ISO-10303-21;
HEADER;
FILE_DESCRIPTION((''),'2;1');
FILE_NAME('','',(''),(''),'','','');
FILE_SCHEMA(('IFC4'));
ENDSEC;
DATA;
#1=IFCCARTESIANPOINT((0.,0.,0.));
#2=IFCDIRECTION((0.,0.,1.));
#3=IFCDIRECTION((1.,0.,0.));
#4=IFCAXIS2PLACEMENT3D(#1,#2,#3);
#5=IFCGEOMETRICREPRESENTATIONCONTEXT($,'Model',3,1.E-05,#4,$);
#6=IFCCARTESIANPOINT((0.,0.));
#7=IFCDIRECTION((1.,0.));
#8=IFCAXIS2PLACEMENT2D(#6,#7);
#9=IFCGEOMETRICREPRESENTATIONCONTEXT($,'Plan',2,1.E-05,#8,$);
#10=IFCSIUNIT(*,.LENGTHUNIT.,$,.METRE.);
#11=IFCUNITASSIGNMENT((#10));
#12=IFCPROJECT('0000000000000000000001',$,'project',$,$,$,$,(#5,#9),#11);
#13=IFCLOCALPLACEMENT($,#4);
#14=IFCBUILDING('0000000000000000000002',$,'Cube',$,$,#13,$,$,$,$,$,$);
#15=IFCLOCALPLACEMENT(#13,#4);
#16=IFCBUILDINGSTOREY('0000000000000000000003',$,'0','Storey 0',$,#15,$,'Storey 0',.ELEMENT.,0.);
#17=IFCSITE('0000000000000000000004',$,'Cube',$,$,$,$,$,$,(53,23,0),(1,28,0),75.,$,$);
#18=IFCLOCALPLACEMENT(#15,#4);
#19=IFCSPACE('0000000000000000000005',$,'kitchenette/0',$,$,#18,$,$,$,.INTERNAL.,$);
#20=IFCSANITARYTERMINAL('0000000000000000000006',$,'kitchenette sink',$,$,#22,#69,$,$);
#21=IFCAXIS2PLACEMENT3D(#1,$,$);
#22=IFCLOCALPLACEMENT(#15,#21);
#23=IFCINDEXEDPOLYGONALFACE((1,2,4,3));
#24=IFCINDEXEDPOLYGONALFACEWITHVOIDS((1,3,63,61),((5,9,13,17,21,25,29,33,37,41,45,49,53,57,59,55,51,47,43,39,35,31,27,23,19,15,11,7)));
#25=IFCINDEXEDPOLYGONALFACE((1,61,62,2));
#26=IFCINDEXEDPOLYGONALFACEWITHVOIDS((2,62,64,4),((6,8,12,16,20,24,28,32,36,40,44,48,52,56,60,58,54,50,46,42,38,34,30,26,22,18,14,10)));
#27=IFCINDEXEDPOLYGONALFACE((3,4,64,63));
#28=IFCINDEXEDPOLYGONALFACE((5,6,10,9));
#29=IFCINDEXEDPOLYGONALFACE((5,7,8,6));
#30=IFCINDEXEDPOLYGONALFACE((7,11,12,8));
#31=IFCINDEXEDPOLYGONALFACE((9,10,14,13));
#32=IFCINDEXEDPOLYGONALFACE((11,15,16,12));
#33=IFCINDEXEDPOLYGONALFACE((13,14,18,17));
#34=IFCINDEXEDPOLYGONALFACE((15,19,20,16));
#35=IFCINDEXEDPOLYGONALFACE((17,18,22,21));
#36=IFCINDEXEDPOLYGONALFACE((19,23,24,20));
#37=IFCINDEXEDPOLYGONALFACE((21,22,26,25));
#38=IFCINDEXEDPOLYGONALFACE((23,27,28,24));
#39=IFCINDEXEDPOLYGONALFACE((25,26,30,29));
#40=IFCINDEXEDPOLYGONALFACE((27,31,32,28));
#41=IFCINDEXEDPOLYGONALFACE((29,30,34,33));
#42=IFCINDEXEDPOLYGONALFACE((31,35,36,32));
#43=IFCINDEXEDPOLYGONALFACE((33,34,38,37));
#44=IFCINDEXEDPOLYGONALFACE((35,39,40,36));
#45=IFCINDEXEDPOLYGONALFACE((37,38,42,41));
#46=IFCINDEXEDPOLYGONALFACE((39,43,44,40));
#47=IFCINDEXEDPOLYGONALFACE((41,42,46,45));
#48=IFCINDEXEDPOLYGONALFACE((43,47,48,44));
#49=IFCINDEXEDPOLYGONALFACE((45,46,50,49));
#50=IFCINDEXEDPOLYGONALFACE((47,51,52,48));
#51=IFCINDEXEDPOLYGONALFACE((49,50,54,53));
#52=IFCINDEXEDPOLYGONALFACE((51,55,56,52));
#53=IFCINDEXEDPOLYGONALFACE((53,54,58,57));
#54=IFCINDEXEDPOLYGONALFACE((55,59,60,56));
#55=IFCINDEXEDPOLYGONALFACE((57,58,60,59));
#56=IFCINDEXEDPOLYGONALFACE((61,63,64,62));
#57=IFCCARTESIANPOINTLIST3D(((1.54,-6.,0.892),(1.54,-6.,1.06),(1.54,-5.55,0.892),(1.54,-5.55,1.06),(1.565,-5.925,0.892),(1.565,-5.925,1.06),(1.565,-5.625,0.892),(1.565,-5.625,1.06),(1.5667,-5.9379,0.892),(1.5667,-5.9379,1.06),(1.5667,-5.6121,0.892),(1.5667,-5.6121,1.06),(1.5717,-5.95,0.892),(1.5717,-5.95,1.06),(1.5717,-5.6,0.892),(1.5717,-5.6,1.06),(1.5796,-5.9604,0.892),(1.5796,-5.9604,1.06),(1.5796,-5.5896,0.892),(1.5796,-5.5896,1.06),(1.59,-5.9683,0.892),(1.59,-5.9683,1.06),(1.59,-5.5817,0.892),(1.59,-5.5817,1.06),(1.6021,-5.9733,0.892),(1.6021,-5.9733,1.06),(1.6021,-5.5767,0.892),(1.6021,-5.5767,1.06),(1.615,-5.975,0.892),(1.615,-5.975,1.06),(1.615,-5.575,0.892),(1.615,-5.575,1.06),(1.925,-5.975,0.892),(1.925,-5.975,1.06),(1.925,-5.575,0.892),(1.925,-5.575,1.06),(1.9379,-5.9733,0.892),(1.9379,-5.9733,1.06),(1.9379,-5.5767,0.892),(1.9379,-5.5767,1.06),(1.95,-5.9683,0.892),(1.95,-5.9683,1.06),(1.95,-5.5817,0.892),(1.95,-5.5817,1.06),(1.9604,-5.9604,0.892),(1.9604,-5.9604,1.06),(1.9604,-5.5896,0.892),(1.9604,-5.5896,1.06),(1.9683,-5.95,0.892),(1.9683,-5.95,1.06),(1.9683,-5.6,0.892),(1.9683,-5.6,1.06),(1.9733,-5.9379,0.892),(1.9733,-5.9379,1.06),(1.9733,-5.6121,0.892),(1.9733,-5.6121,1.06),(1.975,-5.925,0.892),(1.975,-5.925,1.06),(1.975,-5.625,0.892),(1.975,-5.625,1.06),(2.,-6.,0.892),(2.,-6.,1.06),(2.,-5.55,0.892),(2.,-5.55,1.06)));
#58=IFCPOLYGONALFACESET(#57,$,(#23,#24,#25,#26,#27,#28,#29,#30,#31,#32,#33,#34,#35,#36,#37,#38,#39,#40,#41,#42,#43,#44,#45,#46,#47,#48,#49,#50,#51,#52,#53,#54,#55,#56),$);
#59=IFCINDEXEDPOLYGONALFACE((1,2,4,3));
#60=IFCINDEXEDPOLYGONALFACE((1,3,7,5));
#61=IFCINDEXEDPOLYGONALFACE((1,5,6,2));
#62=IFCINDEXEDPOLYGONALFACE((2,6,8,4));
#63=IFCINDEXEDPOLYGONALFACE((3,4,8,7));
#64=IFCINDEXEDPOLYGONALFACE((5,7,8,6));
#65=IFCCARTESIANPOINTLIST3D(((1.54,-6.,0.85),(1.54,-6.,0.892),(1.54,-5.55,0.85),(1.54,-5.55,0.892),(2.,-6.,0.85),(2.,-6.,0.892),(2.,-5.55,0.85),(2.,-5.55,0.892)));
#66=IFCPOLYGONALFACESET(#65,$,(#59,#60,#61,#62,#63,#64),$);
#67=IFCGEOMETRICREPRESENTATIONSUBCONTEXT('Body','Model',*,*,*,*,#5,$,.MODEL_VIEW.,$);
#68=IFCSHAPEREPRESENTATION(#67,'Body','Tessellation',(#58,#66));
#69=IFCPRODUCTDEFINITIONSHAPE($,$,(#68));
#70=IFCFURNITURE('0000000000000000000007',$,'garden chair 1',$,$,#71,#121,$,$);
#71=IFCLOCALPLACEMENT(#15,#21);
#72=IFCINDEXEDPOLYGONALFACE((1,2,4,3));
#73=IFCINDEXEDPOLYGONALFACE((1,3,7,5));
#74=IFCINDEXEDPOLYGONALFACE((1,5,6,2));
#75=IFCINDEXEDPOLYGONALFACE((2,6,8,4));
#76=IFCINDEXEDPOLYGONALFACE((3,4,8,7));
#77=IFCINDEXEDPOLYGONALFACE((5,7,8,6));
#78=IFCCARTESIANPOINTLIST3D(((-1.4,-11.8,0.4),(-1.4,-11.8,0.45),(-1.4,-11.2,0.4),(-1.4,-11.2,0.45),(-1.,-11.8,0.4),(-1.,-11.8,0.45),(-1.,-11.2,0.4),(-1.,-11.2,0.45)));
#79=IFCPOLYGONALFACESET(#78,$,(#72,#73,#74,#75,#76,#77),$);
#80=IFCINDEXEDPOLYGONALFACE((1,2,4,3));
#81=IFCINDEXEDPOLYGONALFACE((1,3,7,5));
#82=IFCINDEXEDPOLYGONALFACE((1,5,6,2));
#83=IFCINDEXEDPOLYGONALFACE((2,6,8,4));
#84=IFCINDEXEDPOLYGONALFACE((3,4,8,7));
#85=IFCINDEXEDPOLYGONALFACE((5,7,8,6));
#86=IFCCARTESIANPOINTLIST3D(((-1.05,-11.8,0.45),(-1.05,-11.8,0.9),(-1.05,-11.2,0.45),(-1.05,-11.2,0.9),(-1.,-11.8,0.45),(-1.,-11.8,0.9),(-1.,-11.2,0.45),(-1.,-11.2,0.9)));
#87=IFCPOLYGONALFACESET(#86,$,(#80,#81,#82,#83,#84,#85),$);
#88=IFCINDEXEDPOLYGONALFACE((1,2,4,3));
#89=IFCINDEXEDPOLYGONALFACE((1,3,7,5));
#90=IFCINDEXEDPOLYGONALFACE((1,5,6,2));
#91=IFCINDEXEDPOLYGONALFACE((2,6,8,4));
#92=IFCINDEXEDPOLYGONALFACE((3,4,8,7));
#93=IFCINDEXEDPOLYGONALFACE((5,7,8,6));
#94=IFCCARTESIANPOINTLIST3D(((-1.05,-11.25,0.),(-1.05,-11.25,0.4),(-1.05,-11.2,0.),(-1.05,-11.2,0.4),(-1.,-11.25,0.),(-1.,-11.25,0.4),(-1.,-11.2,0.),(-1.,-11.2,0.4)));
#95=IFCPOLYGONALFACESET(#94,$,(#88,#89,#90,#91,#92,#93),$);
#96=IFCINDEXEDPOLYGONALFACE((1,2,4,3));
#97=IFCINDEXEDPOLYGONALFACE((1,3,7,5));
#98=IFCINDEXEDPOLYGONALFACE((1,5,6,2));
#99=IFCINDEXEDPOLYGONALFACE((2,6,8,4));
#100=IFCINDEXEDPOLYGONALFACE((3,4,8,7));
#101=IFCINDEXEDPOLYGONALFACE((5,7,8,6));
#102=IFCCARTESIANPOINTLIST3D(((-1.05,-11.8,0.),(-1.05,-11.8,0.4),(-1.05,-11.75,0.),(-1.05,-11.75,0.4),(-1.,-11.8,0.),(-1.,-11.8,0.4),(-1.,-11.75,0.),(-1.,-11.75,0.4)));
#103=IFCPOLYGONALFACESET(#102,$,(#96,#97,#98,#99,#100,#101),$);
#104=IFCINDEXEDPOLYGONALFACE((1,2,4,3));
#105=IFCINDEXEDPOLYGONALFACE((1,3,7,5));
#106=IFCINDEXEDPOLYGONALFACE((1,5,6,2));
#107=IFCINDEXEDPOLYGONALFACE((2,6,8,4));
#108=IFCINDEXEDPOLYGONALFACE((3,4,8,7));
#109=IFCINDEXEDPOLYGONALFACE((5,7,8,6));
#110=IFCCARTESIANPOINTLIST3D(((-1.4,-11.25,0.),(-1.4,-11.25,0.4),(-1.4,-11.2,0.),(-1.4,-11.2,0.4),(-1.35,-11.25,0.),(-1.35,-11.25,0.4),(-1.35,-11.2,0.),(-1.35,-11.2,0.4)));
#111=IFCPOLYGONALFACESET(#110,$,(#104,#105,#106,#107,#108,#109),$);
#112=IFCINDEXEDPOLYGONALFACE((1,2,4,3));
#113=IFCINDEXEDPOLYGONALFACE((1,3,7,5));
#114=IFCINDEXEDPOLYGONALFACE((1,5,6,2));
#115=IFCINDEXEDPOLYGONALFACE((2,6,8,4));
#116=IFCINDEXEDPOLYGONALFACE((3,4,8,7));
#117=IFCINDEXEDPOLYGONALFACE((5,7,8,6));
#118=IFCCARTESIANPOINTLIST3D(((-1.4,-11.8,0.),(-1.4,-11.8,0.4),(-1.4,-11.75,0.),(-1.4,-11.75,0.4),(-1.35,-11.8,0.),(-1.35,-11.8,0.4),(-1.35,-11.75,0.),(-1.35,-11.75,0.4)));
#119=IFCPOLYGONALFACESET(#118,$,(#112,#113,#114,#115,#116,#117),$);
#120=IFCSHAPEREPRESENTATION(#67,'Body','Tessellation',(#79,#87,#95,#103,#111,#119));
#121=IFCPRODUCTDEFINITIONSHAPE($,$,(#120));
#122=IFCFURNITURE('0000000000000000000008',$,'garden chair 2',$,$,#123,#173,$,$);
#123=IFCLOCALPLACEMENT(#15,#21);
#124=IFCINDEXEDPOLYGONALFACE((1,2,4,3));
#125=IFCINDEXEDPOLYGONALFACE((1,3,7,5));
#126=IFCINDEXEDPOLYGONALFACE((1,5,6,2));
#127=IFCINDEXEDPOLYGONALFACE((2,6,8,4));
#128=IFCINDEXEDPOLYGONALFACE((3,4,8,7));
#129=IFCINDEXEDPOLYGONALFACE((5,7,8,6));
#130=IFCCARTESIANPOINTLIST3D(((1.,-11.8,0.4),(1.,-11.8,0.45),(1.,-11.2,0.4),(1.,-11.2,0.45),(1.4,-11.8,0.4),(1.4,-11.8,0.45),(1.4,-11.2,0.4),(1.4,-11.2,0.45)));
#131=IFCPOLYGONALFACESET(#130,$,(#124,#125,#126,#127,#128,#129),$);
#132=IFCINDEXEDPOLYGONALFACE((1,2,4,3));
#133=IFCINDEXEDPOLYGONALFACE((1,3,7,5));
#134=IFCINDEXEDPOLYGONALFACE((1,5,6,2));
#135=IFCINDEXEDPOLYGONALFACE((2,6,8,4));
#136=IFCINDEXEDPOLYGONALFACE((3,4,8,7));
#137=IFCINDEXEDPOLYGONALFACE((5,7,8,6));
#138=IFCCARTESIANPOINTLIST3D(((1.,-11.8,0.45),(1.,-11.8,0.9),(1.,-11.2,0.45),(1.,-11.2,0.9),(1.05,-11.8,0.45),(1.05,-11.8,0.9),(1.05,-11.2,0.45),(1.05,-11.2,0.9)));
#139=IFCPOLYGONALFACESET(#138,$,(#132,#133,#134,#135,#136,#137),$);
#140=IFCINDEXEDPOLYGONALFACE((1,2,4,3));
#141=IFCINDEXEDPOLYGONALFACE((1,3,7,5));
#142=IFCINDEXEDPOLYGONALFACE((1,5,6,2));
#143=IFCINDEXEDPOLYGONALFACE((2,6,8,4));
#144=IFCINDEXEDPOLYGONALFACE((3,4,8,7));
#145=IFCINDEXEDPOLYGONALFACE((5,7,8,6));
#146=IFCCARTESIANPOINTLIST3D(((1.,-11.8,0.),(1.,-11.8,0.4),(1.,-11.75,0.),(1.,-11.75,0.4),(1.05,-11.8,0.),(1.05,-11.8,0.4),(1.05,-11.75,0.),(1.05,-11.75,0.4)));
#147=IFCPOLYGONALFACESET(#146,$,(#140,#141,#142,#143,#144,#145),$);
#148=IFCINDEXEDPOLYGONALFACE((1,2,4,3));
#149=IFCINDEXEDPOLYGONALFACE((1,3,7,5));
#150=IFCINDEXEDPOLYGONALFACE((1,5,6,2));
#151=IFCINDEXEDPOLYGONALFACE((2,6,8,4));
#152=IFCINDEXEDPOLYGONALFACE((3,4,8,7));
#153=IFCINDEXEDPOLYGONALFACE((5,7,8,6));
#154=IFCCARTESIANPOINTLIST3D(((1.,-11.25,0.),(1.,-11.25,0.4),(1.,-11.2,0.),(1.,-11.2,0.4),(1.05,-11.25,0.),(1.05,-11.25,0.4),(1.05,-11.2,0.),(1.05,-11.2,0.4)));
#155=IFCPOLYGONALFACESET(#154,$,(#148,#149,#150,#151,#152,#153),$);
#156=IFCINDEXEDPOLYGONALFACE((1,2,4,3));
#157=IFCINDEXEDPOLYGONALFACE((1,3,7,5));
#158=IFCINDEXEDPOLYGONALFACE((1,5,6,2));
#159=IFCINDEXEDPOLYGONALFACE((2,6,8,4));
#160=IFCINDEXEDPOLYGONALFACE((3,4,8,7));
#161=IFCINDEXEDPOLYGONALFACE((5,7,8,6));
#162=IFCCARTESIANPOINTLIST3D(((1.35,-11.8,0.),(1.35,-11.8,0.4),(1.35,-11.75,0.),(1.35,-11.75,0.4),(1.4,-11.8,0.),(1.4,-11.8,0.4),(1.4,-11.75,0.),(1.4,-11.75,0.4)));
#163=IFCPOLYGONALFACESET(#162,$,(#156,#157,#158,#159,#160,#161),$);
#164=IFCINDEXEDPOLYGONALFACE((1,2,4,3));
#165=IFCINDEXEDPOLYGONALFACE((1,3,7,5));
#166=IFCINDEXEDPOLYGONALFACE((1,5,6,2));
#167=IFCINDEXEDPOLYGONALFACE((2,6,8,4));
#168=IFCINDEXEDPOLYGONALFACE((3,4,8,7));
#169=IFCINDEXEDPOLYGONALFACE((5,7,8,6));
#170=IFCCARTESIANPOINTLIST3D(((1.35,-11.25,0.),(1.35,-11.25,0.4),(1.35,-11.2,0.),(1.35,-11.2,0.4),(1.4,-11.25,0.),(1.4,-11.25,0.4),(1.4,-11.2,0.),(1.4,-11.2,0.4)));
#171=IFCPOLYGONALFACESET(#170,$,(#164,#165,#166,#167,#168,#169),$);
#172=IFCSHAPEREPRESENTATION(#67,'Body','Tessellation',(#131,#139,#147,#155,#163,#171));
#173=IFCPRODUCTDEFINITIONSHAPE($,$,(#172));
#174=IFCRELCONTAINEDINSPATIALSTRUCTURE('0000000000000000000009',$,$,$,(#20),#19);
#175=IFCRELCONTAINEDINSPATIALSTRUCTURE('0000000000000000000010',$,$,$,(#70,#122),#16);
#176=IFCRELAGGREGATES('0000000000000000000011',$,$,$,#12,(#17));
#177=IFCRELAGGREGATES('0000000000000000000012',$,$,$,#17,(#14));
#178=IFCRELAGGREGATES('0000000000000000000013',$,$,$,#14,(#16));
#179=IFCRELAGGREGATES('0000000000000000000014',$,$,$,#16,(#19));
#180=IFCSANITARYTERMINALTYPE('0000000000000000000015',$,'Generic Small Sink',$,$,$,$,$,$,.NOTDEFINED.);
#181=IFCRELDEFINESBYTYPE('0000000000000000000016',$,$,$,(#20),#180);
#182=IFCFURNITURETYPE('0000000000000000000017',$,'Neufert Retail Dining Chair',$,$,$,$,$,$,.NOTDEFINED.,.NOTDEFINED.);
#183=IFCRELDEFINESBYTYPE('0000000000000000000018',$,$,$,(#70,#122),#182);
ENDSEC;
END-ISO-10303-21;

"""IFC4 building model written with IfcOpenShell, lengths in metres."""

from ifc_helpers import new_model, entity, si_unit, frame, origin_with_axes, origin_2d_with_axis, place, context, subcontext, project, spatial, line, indexed_curve, outline, extrude, shape, source, transform, mapped, type_object, type_shapes, element, save


model = new_model("IFC4")

# Units and contexts
model_context = context("Model", 3, precision=1e-05, world=origin_with_axes())
plan_context = context("Plan", 2, precision=1e-05, world=origin_2d_with_axis())
body_context_1 = subcontext(model_context, "Body", "Model", "MODEL_VIEW")
body_context_2 = subcontext(plan_context, "Body", "Plan", "PLAN_VIEW")
ifc_project = project(units=[si_unit("LENGTHUNIT", "METRE")], contexts=[model_context, plan_context])

# Site, building, storey
site = spatial("IfcSite", under=ifc_project, Name="Cube", RefLatitude=(53, 23, 0), RefLongitude=(1, 28, 0), RefElevation=75.0)
building_placement = place(None, origin_with_axes())
building = spatial("IfcBuilding", under=site, at=building_placement, Name="Cube")
storey_placement = place(building_placement, origin_with_axes())
storey = spatial("IfcBuildingStorey", under=building, at=storey_placement, Name="0", Description="Storey 0", LongName="Storey 0", CompositionType="ELEMENT", Elevation=0.0)

# Shared definitions
space_1_placement = place(storey_placement, origin_with_axes())
space_1 = spatial("IfcSpace", under=storey, at=space_1_placement, Name="kitchenette/0", PredefinedType="INTERNAL")

# Sanitary terminal
sanitary_terminal_type_1 = type_object("IfcSanitaryTerminalType", Name="Generic Small Sink", PredefinedType="NOTDEFINED")
shared_indexed_poly_curve_1 = entity("IfcIndexedPolyCurve", entity("IfcCartesianPointList2D", [[0.0, 0.0], [0.45, 0.0], [0.45, 0.46], [0.0, 0.46]]), [entity("IfcLineIndex", [1, 2, 3, 4, 1])])
shared_shape_1 = source(origin_with_axes(), body_context_1, "Body", "SweptSolid", [
    entity("IfcExtrudedAreaSolid", entity("IfcArbitraryProfileDefWithVoids", "AREA", None, shared_indexed_poly_curve_1, [entity("IfcIndexedPolyCurve", entity("IfcCartesianPointList2D", [[0.025, 0.075], [0.0396, 0.0396], [0.075, 0.025], [0.375, 0.025], [0.4104, 0.0396], [0.425, 0.075], [0.425, 0.385], [0.4104, 0.4204], [0.375, 0.435], [0.075, 0.435], [0.0396, 0.4204], [0.025, 0.385]]), [entity("IfcLineIndex", [12, 1]), entity("IfcArcIndex", [1, 2, 3]), entity("IfcLineIndex", [3, 4]), entity("IfcArcIndex", [4, 5, 6]), entity("IfcLineIndex", [6, 7]), entity("IfcArcIndex", [7, 8, 9]), entity("IfcLineIndex", [9, 10]), entity("IfcArcIndex", [10, 11, 12]), entity("IfcLineIndex", [12, 1])])]), entity("IfcAxis2Placement3D", entity("IfcCartesianPoint", [-0.225, -0.46, 0.042]), entity("IfcDirection", [0.0, 0.0, 1.0]), entity("IfcDirection", [1.0, 0.0, 0.0])), entity("IfcDirection", [0.0, 0.0, 1.0]), 0.168),
    entity("IfcExtrudedAreaSolid", entity("IfcArbitraryClosedProfileDef", "AREA", None, shared_indexed_poly_curve_1), entity("IfcAxis2Placement3D", entity("IfcCartesianPoint", [-0.225, -0.46, 0.0]), entity("IfcDirection", [0.0, 0.0, 1.0]), entity("IfcDirection", [1.0, 0.0, 0.0])), entity("IfcDirection", [0.0, 0.0, 1.0]), 0.042),
])
shared_shape_2 = source(origin_with_axes(), body_context_2, "Body", "Curve2D", [
    entity("IfcIndexedPolyCurve", entity("IfcCartesianPointList2D", [[-0.225, -0.46], [0.225, -0.46], [0.225, 0.0], [-0.225, 0.0]]), [entity("IfcLineIndex", [1, 2, 3, 4, 1])]),
    entity("IfcIndexedPolyCurve", entity("IfcCartesianPointList2D", [[-0.2, -0.385], [-0.1854, -0.4204], [-0.15, -0.435], [0.15, -0.435], [0.1854, -0.4204], [0.2, -0.385], [0.2, -0.075], [0.1854, -0.0396], [0.15, -0.025], [-0.15, -0.025], [-0.1854, -0.0396], [-0.2, -0.075]]), [entity("IfcLineIndex", [12, 1]), entity("IfcArcIndex", [1, 2, 3]), entity("IfcLineIndex", [3, 4]), entity("IfcArcIndex", [4, 5, 6]), entity("IfcLineIndex", [6, 7]), entity("IfcArcIndex", [7, 8, 9]), entity("IfcLineIndex", [9, 10]), entity("IfcArcIndex", [10, 11, 12]), entity("IfcLineIndex", [12, 1])]),
    entity("IfcCircle", entity("IfcAxis2Placement2D", entity("IfcCartesianPoint", [0.0, -0.125])), 0.025),
    entity("IfcIndexedPolyCurve", entity("IfcCartesianPointList2D", [[0.0, -0.0125], [0.0, -0.1325]])),
])
type_shapes(sanitary_terminal_type_1, [shared_shape_1, shared_shape_2])
sanitary_terminal_1_placement = place(space_1_placement, frame((2.0, -5.775, 0.85), z_axis=(0.0, 0.0, 1.0), x_axis=(0.0, -1.0, 0.0)))
element("IfcSanitaryTerminal", 1, at=sanitary_terminal_1_placement, inside=space_1, type_object=sanitary_terminal_type_1, Name="kitchenette sink", shapes=[
    shape(body_context_1, "Body", "MappedRepresentation", [mapped(shared_shape_1, transform((0.0, 0.0, 0.0), x_axis=(1.0, 0.0, 0.0), y_axis=(0.0, 1.0, 0.0), z_axis=(0.0, 0.0, 1.0), scale=1.0))]),
    shape(body_context_2, "Body", "MappedRepresentation", [mapped(shared_shape_2, transform((0.0, 0.0, 0.0), x_axis=(1.0, 0.0, 0.0), y_axis=(0.0, 1.0, 0.0), z_axis=(0.0, 0.0, 1.0), scale=1.0))]),
])

# Furniture
furniture_type_1 = type_object("IfcFurnitureType", Name="Neufert Retail Dining Chair", AssemblyPlace="NOTDEFINED", PredefinedType="NOTDEFINED")
shared_shape_3 = source(origin_with_axes(), body_context_1, "Body", "SweptSolid", [
    extrude(outline(indexed_curve([(-0.3, 0.0), (0.3, 0.0), (0.3, -0.4), (-0.3, -0.4)], segments=[line(1, 2, 3, 4, 1)])), frame((0.0, 0.0, 0.45), z_axis=(0.0, 0.0, 1.0), x_axis=(1.0, 0.0, 0.0)), (0.0, 0.0, -1.0), 0.05),
    extrude(outline(indexed_curve([(-0.3, 0.0), (0.3, 0.0), (0.3, -0.05), (-0.3, -0.05)], segments=[line(1, 2, 3, 4, 1)])), frame((0.0, 0.0, 0.9), z_axis=(0.0, 0.0, 1.0), x_axis=(1.0, 0.0, 0.0)), (0.0, 0.0, -1.0), 0.45),
    extrude(outline(indexed_curve([(-0.3, 0.0), (-0.25, 0.0), (-0.25, -0.05), (-0.3, -0.05)], segments=[line(1, 2, 3, 4, 1)])), origin_with_axes(), (0.0, 0.0, 1.0), 0.4),
    extrude(outline(indexed_curve([(0.3, 0.0), (0.25, 0.0), (0.25, -0.05), (0.3, -0.05)], segments=[line(1, 2, 3, 4, 1)])), origin_with_axes(), (0.0, 0.0, 1.0), 0.4),
    extrude(outline(indexed_curve([(-0.3, -0.4), (-0.25, -0.4), (-0.25, -0.35), (-0.3, -0.35)], segments=[line(1, 2, 3, 4, 1)])), origin_with_axes(), (0.0, 0.0, 1.0), 0.4),
    extrude(outline(indexed_curve([(0.3, -0.4), (0.25, -0.4), (0.25, -0.35), (0.3, -0.35)], segments=[line(1, 2, 3, 4, 1)])), origin_with_axes(), (0.0, 0.0, 1.0), 0.4),
])
shared_shape_4 = source(origin_with_axes(), body_context_2, "Body", "Curve2D", [
    entity("IfcIndexedPolyCurve", entity("IfcCartesianPointList2D", [[-0.3, -0.4], [0.3, -0.4]])),
    entity("IfcIndexedPolyCurve", entity("IfcCartesianPointList2D", [[-0.3, -0.4], [-0.3, -0.3], [-0.2121, -0.0879], [0.0, 0.0], [0.2121, -0.0879], [0.3, -0.3], [0.3, -0.4]]), [entity("IfcLineIndex", [1, 2]), entity("IfcArcIndex", [2, 3, 4]), entity("IfcArcIndex", [4, 5, 6]), entity("IfcLineIndex", [6, 7])]),
    entity("IfcIndexedPolyCurve", entity("IfcCartesianPointList2D", [[-0.26, -0.4], [-0.26, -0.3], [-0.1838, -0.1162], [0.0, -0.04], [0.1838, -0.1162], [0.26, -0.3], [0.26, -0.4]]), [entity("IfcLineIndex", [1, 2]), entity("IfcArcIndex", [2, 3, 4]), entity("IfcArcIndex", [4, 5, 6]), entity("IfcLineIndex", [6, 7])]),
])
type_shapes(furniture_type_1, [shared_shape_3, shared_shape_4])
for number, where, z_axis, x_axis, name in (
    (2, (-1.0, -11.5, 0.0), (0.0, 0.0, 1.0), (0.0, -1.0, 0.0), "garden chair 1"),
    (3, (1.0, -11.5, 0.0), (0.0, 0.0, 1.0), (0.0, 1.0, 0.0), "garden chair 2"),
):
    element("IfcFurniture", number, at=place(storey_placement, frame(where, z_axis=z_axis, x_axis=x_axis)), inside=storey, type_object=furniture_type_1, Name=name, shapes=[
        shape(body_context_1, "Body", "MappedRepresentation", [mapped(shared_shape_3, transform((0.0, 0.0, 0.0), x_axis=(1.0, 0.0, 0.0), y_axis=(0.0, 1.0, 0.0), z_axis=(0.0, 0.0, 1.0), scale=1.0))]),
        shape(body_context_2, "Body", "MappedRepresentation", [mapped(shared_shape_4, transform((0.0, 0.0, 0.0), x_axis=(1.0, 0.0, 0.0), y_axis=(0.0, 1.0, 0.0), z_axis=(0.0, 0.0, 1.0), scale=1.0))]),
    ])

save(model, "model.ifc")
